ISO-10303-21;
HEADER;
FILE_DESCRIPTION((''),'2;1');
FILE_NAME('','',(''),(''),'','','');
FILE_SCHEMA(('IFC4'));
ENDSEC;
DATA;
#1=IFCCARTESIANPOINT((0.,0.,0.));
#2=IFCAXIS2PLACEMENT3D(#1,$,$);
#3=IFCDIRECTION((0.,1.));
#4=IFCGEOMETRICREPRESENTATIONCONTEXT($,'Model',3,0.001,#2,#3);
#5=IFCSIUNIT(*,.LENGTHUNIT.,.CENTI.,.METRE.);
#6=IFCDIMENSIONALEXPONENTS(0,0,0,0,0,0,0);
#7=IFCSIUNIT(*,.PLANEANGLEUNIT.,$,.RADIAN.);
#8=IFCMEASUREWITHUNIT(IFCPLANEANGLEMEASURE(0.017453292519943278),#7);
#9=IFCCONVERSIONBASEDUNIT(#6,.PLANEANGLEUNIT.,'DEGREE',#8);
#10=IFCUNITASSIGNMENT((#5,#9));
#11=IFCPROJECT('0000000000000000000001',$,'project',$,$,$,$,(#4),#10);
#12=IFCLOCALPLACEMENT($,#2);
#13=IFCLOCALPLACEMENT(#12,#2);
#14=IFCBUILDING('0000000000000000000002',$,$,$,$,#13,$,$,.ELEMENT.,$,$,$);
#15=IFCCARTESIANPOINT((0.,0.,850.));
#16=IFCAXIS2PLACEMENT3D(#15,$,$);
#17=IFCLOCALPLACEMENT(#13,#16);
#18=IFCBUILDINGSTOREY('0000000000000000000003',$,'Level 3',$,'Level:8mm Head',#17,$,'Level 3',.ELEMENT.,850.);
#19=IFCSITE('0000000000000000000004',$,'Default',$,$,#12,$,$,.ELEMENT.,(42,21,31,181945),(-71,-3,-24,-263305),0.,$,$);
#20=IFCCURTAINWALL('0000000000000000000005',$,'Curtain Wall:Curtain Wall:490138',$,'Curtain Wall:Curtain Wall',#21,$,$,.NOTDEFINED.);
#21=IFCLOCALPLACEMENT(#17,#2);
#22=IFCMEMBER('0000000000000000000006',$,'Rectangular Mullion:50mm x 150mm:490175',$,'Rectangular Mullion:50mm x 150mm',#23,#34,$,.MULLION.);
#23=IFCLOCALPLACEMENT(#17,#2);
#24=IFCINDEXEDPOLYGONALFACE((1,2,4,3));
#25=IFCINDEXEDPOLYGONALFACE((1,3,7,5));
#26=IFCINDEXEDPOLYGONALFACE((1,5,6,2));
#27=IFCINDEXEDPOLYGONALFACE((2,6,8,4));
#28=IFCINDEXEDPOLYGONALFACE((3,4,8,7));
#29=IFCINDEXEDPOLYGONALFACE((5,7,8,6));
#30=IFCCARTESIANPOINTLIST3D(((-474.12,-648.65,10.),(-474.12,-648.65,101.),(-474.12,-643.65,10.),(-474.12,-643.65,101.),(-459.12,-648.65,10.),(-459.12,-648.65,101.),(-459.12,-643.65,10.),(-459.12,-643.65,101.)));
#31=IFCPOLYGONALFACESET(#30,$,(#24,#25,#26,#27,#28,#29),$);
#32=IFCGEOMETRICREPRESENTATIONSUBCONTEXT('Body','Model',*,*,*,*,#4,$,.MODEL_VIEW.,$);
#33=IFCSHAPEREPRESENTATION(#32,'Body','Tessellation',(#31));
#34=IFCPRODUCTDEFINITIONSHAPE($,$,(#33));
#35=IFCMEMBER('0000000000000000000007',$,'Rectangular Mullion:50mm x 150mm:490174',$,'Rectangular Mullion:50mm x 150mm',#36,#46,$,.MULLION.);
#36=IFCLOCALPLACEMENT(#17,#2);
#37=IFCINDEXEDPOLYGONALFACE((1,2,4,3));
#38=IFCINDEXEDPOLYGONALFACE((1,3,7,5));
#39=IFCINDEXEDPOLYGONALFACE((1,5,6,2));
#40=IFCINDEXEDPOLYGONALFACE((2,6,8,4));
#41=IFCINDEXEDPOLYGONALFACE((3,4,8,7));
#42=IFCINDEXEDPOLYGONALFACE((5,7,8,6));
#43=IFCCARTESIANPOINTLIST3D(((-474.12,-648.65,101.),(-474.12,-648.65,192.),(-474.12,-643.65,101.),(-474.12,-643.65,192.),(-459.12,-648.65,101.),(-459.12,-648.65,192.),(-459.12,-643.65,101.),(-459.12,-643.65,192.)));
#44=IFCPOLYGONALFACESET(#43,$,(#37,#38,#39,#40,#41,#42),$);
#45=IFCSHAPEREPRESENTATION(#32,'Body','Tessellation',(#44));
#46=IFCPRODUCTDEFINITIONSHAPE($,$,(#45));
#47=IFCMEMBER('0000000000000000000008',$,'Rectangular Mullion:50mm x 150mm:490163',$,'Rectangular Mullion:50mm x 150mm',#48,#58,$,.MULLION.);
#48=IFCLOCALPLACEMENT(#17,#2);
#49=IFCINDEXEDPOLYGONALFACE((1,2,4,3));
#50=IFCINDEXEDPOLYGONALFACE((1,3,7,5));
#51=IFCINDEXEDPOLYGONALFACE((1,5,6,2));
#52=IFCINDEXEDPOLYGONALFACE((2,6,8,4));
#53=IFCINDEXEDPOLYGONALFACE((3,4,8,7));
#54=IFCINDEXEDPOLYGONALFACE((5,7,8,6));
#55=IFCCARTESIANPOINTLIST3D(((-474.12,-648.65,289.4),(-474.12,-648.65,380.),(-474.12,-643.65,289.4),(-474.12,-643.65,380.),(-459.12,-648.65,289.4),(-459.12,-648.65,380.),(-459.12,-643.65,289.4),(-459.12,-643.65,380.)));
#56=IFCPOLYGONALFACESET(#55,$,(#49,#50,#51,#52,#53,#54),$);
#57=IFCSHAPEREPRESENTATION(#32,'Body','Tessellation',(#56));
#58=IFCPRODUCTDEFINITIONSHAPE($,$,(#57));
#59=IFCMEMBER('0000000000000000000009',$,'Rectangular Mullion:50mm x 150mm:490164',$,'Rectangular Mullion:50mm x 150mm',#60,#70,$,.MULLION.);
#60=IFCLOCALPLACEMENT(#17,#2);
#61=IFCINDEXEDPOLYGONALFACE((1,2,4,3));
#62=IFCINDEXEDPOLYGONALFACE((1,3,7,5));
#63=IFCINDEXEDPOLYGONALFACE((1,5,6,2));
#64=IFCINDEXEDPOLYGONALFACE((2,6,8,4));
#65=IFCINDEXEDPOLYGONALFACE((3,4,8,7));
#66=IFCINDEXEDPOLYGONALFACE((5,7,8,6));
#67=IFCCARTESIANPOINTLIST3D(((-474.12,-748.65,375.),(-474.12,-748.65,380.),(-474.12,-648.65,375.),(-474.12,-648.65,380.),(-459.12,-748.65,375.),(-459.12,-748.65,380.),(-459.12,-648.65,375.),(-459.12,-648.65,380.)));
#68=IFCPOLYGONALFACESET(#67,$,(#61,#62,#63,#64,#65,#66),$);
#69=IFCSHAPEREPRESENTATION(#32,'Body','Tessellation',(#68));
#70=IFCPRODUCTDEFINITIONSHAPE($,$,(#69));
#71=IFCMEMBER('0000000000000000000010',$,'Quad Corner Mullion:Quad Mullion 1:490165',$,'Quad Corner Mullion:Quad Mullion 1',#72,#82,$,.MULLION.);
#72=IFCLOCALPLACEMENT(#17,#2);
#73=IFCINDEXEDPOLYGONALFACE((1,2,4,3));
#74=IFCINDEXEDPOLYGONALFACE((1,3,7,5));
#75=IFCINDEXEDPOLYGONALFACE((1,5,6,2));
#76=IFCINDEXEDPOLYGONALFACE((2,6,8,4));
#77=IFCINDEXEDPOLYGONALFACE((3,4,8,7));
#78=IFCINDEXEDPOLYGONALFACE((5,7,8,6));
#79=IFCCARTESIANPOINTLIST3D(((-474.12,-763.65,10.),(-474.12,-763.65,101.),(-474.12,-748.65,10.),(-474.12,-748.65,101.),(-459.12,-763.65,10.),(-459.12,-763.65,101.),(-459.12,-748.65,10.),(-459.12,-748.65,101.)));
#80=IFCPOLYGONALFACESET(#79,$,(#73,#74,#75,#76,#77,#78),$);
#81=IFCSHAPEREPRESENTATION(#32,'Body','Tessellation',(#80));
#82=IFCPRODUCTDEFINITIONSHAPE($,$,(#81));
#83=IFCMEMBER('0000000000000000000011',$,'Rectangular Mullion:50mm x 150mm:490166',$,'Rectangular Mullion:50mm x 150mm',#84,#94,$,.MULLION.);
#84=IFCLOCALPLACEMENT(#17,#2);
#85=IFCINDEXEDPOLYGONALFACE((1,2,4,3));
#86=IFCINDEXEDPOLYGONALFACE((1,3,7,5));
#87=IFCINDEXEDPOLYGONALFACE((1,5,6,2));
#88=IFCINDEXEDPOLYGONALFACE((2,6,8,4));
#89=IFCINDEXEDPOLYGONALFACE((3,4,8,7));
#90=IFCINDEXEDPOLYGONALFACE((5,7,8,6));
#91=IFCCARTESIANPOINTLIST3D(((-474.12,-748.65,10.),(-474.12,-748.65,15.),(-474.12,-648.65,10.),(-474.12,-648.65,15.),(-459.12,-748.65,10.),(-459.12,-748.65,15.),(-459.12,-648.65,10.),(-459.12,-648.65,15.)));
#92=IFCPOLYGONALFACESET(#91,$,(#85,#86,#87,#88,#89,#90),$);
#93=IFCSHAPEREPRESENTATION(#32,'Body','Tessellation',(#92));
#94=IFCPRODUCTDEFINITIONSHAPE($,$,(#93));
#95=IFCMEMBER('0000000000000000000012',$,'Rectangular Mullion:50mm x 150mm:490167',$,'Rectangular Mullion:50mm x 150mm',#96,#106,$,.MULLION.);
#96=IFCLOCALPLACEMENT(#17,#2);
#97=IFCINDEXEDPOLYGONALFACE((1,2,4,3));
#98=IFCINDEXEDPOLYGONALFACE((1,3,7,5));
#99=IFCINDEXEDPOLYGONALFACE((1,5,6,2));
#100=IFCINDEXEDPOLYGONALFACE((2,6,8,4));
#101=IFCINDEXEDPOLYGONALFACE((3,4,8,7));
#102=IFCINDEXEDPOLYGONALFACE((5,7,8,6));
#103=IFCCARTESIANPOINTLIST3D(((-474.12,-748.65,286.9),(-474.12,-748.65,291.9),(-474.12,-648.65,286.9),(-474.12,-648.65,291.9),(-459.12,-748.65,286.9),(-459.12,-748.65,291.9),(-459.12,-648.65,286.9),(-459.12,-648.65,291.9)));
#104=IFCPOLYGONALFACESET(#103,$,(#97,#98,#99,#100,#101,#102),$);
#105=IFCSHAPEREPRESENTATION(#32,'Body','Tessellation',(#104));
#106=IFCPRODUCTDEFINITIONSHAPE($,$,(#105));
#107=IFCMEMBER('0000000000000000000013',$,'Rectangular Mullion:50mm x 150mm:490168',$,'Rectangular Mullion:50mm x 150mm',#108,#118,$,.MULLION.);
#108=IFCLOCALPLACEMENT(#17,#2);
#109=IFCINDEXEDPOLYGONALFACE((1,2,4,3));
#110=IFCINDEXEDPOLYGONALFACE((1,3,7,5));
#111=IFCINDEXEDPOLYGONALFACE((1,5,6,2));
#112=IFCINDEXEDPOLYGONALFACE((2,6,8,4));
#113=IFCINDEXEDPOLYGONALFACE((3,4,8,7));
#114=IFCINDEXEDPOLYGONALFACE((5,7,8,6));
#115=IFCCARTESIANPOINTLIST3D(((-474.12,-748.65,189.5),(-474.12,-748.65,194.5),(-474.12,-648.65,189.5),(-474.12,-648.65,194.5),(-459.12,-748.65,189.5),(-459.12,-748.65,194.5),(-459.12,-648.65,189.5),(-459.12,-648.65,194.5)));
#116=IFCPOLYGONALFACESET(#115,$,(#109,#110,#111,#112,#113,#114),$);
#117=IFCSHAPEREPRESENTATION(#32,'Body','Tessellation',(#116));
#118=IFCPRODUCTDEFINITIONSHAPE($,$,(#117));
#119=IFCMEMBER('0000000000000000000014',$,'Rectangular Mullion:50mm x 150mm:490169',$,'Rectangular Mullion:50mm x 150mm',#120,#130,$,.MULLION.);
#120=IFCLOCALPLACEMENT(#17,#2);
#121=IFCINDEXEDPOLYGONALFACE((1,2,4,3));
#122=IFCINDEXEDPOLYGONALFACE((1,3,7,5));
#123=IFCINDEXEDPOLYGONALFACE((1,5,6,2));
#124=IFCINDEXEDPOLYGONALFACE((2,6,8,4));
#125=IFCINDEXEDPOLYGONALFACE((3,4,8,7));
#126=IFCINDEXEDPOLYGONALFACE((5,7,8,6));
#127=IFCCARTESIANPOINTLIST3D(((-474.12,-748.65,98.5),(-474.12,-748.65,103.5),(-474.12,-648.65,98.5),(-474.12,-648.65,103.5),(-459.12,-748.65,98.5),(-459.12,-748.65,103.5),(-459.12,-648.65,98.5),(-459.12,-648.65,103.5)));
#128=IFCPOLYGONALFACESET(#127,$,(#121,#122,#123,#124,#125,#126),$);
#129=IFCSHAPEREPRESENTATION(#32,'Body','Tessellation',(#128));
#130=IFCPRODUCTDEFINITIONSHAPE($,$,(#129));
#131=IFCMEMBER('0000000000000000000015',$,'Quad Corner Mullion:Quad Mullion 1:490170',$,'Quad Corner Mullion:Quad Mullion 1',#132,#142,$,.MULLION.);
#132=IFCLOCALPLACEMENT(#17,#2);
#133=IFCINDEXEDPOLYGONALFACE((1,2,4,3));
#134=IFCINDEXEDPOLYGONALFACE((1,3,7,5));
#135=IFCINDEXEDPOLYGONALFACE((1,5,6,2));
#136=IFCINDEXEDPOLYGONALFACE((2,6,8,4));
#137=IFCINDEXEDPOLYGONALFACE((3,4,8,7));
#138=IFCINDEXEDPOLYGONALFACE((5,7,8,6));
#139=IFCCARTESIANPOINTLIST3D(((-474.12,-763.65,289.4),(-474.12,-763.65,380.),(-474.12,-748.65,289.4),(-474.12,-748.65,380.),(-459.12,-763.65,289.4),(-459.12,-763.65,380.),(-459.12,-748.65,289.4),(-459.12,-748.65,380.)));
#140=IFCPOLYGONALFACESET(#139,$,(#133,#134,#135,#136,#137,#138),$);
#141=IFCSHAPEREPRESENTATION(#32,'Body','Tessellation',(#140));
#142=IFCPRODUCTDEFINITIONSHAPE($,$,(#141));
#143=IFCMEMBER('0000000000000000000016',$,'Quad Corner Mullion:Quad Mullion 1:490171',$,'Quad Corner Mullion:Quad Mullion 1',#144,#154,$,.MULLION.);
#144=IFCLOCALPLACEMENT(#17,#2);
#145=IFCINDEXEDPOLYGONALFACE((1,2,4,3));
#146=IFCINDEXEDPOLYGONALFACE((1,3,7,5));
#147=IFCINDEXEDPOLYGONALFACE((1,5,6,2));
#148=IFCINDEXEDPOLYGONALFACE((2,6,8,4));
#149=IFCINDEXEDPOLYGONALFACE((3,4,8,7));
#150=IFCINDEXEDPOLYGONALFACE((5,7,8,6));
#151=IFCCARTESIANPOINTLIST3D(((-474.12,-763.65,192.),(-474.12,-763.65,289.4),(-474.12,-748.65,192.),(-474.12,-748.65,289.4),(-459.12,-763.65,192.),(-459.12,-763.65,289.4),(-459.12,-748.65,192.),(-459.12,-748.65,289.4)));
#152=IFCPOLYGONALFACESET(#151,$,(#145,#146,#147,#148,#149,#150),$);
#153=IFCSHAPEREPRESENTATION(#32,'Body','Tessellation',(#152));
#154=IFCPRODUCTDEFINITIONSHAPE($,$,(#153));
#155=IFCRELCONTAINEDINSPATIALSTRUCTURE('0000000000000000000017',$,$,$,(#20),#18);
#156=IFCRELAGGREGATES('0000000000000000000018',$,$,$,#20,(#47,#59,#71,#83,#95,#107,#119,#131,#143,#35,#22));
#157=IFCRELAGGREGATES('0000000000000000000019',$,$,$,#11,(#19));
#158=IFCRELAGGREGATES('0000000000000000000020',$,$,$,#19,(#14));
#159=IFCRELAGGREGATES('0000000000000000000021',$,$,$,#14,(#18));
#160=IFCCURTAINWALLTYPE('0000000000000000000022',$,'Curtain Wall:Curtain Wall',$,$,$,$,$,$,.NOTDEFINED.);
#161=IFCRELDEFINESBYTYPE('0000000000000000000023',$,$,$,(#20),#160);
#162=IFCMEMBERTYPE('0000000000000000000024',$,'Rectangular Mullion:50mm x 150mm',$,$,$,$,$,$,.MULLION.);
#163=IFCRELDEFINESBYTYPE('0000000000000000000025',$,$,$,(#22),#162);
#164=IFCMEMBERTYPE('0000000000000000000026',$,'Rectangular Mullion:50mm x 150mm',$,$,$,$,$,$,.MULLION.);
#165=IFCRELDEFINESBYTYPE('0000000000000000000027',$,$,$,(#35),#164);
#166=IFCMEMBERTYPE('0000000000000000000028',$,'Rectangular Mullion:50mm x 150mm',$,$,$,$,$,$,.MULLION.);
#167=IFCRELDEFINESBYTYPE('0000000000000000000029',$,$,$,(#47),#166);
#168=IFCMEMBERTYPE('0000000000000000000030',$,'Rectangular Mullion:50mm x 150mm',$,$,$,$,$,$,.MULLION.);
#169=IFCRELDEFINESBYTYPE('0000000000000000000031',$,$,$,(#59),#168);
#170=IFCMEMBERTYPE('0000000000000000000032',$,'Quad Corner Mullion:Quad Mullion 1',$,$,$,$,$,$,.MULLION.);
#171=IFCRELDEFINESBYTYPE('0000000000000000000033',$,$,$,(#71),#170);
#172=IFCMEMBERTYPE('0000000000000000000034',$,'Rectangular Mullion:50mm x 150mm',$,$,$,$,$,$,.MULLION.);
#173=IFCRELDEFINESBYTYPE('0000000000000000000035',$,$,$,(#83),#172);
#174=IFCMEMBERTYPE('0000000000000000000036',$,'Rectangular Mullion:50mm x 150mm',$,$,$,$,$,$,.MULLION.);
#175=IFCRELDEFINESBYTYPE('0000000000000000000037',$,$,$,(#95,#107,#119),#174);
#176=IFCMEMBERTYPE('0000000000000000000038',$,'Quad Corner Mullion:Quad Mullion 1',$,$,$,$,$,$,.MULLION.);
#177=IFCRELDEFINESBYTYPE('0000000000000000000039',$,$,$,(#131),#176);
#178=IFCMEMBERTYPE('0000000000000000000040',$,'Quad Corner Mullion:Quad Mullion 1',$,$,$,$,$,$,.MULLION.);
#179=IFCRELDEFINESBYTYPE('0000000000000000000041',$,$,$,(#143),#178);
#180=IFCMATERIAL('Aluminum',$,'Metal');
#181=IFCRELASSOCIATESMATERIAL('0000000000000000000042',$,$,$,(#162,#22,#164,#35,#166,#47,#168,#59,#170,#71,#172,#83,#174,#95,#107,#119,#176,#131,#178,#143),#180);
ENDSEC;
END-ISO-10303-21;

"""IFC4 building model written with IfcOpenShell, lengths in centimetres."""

from ifc_helpers import new_model, entity, si_unit, converted_unit, direction, frame, origin, place, context, subcontext, project, spatial, indexed_curve, outline, extrude, source, transform, mapped, material, type_object, type_shapes, element, aggregate, save


model = new_model("IFC4")

# Units and contexts
model_context = context("Model", 3, precision=0.001, world=origin(), true_north=direction((0.0, 1.0)))
body_context = subcontext(model_context, "Body", "Model", "MODEL_VIEW")
ifc_project = project(units=[si_unit("LENGTHUNIT", "METRE", prefix="CENTI"), converted_unit("PLANEANGLEUNIT", "DEGREE", entity("IfcPlaneAngleMeasure", 0.017453292519943278), si_unit("PLANEANGLEUNIT", "RADIAN"), dimensions=[0, 0, 0, 0, 0, 0, 0])], contexts=[model_context])

# Site, building, storey
site_placement = place(None, origin())
site = spatial("IfcSite", under=ifc_project, at=site_placement, Name="Default", CompositionType="ELEMENT", RefLatitude=(42, 21, 31, 181945), RefLongitude=(-71, -3, -24, -263305), RefElevation=0.0)
building_placement = place(site_placement, origin())
building = spatial("IfcBuilding", under=site, at=building_placement, CompositionType="ELEMENT")
storey_placement = place(building_placement, frame((0.0, 0.0, 850.0)))
storey = spatial("IfcBuildingStorey", under=building, at=storey_placement, Name="Level 3", ObjectType="Level:8mm Head", LongName="Level 3", CompositionType="ELEMENT", Elevation=850.0)

# Curtain wall, members
curtain_wall_type = type_object("IfcCurtainWallType", Name="Curtain Wall:Curtain Wall", PredefinedType="NOTDEFINED")
curtain_wall_1_placement = place(storey_placement, frame((0.0, 0.0, -850.0)))
curtain_wall_1 = element("IfcCurtainWall", 1, at=curtain_wall_1_placement, inside=storey, type_object=curtain_wall_type, Name="Curtain Wall:Curtain Wall:490138", ObjectType="Curtain Wall:Curtain Wall", PredefinedType="NOTDEFINED")
ifc_material_1 = material(Name="Aluminum", Category="Metal")
member_type_1 = type_object("IfcMemberType", Name="Rectangular Mullion:50mm x 150mm", PredefinedType="MULLION", material=ifc_material_1)
shared_shape_1 = source(origin(), body_context, "Body", "SweptSolid", [
    extrude(outline(indexed_curve([(-2.5, -7.5), (2.5, -7.5), (2.5, 7.5), (-2.5, 7.5), (-2.5, -7.5)], self_intersect=False)), frame((-2.5, 0.0, -91.0), z_axis=(0.0, 0.0, 1.0), x_axis=(-1.0, 0.0, 0.0)), (0.0, 0.0, 1.0), 91.0),
])
type_shapes(member_type_1, [shared_shape_1])
member_1_placement = place(curtain_wall_1_placement, frame((-466.62, -643.65, 951.0), z_axis=(0.0, 0.0, 1.0), x_axis=(0.0, 1.0, 0.0)))
member_1 = element("IfcMember", 2, at=member_1_placement, type_object=member_type_1, material=ifc_material_1, Name="Rectangular Mullion:50mm x 150mm:490175", ObjectType="Rectangular Mullion:50mm x 150mm", PredefinedType="MULLION", context=body_context, shape_type="MappedRepresentation", body=[
    mapped(shared_shape_1, transform((0.0, 0.0, 0.0), scale=1.0)),
])
member_type_2 = type_object("IfcMemberType", Name="Rectangular Mullion:50mm x 150mm", PredefinedType="MULLION", material=ifc_material_1)
shared_shape_2 = source(origin(), body_context, "Body", "SweptSolid", [
    extrude(outline(indexed_curve([(-2.5, -7.5), (2.5, -7.5), (2.5, 7.5), (-2.5, 7.5), (-2.5, -7.5)], self_intersect=False)), frame((-2.5, 0.0, -91.0), z_axis=(0.0, 0.0, 1.0), x_axis=(-1.0, 0.0, 0.0)), (0.0, 0.0, 1.0), 91.0),
])
type_shapes(member_type_2, [shared_shape_2])
member_2_placement = place(curtain_wall_1_placement, frame((-466.62, -643.65, 1042.0), z_axis=(0.0, 0.0, 1.0), x_axis=(0.0, 1.0, 0.0)))
member_2 = element("IfcMember", 3, at=member_2_placement, type_object=member_type_2, material=ifc_material_1, Name="Rectangular Mullion:50mm x 150mm:490174", ObjectType="Rectangular Mullion:50mm x 150mm", PredefinedType="MULLION", context=body_context, shape_type="MappedRepresentation", body=[
    mapped(shared_shape_2, transform((0.0, 0.0, 0.0), scale=1.0)),
])
member_type_3 = type_object("IfcMemberType", Name="Rectangular Mullion:50mm x 150mm", PredefinedType="MULLION", material=ifc_material_1)
shared_shape_3 = source(origin(), body_context, "Body", "SweptSolid", [
    extrude(outline(indexed_curve([(-2.5, -7.5), (2.5, -7.5), (2.5, 7.5), (-2.5, 7.5), (-2.5, -7.5)], self_intersect=False)), frame((-2.5, 0.0, -90.6), z_axis=(0.0, 0.0, 1.0), x_axis=(-1.0, 0.0, 0.0)), (0.0, 0.0, 1.0), 90.6),
])
type_shapes(member_type_3, [shared_shape_3])
member_3_placement = place(curtain_wall_1_placement, frame((-466.62, -643.65, 1230.0), z_axis=(0.0, 0.0, 1.0), x_axis=(0.0, 1.0, 0.0)))
member_3 = element("IfcMember", 4, at=member_3_placement, type_object=member_type_3, material=ifc_material_1, Name="Rectangular Mullion:50mm x 150mm:490163", ObjectType="Rectangular Mullion:50mm x 150mm", PredefinedType="MULLION", context=body_context, shape_type="MappedRepresentation", body=[
    mapped(shared_shape_3, transform((0.0, 0.0, 0.0), scale=1.0)),
])
member_type_4 = type_object("IfcMemberType", Name="Rectangular Mullion:50mm x 150mm", PredefinedType="MULLION", material=ifc_material_1)
shared_shape_4 = source(origin(), body_context, "Body", "SweptSolid", [
    extrude(outline(indexed_curve([(-2.5, -7.5), (2.5, -7.5), (2.5, 7.5), (-2.5, 7.5), (-2.5, -7.5)], self_intersect=False)), frame((-2.5, 0.0, -100.0), z_axis=(0.0, 0.0, 1.0), x_axis=(-1.0, 0.0, 0.0)), (0.0, 0.0, 1.0), 100.0),
])
type_shapes(member_type_4, [shared_shape_4])
member_4_placement = place(curtain_wall_1_placement, frame((-466.62, -748.65, 1230.0), z_axis=(0.0, -1.0, 0.0), x_axis=(0.0, 0.0, 1.0)))
member_4 = element("IfcMember", 5, at=member_4_placement, type_object=member_type_4, material=ifc_material_1, Name="Rectangular Mullion:50mm x 150mm:490164", ObjectType="Rectangular Mullion:50mm x 150mm", PredefinedType="MULLION", context=body_context, shape_type="MappedRepresentation", body=[
    mapped(shared_shape_4, transform((0.0, 0.0, 0.0), scale=1.0)),
])
member_type_5 = type_object("IfcMemberType", Name="Quad Corner Mullion:Quad Mullion 1", PredefinedType="MULLION", material=ifc_material_1)
shared_shape_5 = source(origin(), body_context, "Body", "SweptSolid", [
    extrude(outline(indexed_curve([(-7.5, -7.5), (7.5, -7.5), (7.5, 7.5), (-7.5, 7.5), (-7.5, -7.5)], self_intersect=False)), frame((0.0, 0.0, -91.0), z_axis=(0.0, 0.0, 1.0), x_axis=(0.0, 1.0, 0.0)), (0.0, 0.0, 1.0), 91.0),
])
type_shapes(member_type_5, [shared_shape_5])
member_5_placement = place(curtain_wall_1_placement, frame((-466.62, -756.15, 860.0), z_axis=(0.0, 0.0, -1.0), x_axis=(0.0, -1.0, 0.0)))
member_5 = element("IfcMember", 6, at=member_5_placement, type_object=member_type_5, material=ifc_material_1, Name="Quad Corner Mullion:Quad Mullion 1:490165", ObjectType="Quad Corner Mullion:Quad Mullion 1", PredefinedType="MULLION", context=body_context, shape_type="MappedRepresentation", body=[
    mapped(shared_shape_5, transform((0.0, 0.0, 0.0), scale=1.0)),
])
member_type_6 = type_object("IfcMemberType", Name="Rectangular Mullion:50mm x 150mm", PredefinedType="MULLION", material=ifc_material_1)
shared_shape_6 = source(origin(), body_context, "Body", "SweptSolid", [
    extrude(outline(indexed_curve([(-2.5, -7.5), (2.5, -7.5), (2.5, 7.5), (-2.5, 7.5), (-2.5, -7.5)], self_intersect=False)), frame((-2.5, 0.0, -100.0), z_axis=(0.0, 0.0, 1.0), x_axis=(-1.0, 0.0, 0.0)), (0.0, 0.0, 1.0), 100.0),
])
type_shapes(member_type_6, [shared_shape_6])
member_6_placement = place(curtain_wall_1_placement, frame((-466.62, -648.65, 860.0), z_axis=(0.0, 1.0, 0.0), x_axis=(0.0, 0.0, -1.0)))
member_6 = element("IfcMember", 7, at=member_6_placement, type_object=member_type_6, material=ifc_material_1, Name="Rectangular Mullion:50mm x 150mm:490166", ObjectType="Rectangular Mullion:50mm x 150mm", PredefinedType="MULLION", context=body_context, shape_type="MappedRepresentation", body=[
    mapped(shared_shape_6, transform((0.0, 0.0, 0.0), scale=1.0)),
])
member_type_7 = type_object("IfcMemberType", Name="Rectangular Mullion:50mm x 150mm", PredefinedType="MULLION", material=ifc_material_1)
shared_shape_7 = source(origin(), body_context, "Body", "SweptSolid", [
    extrude(outline(indexed_curve([(-2.5, -7.5), (2.5, -7.5), (2.5, 7.5), (-2.5, 7.5), (-2.5, -7.5)], self_intersect=False)), frame((0.0, 0.0, -100.0), z_axis=(0.0, 0.0, 1.0), x_axis=(-1.0, 0.0, 0.0)), (0.0, 0.0, 1.0), 100.0),
])
type_shapes(member_type_7, [shared_shape_7])
member_7_placement = place(curtain_wall_1_placement, frame((-466.62, -748.65, 1139.4), z_axis=(0.0, -1.0, 0.0), x_axis=(0.0, 0.0, 1.0)))
member_7 = element("IfcMember", 8, at=member_7_placement, type_object=member_type_7, material=ifc_material_1, Name="Rectangular Mullion:50mm x 150mm:490167", ObjectType="Rectangular Mullion:50mm x 150mm", PredefinedType="MULLION", context=body_context, shape_type="MappedRepresentation", body=[
    mapped(shared_shape_7, transform((0.0, 0.0, 0.0), scale=1.0)),
])
member_8_placement = place(curtain_wall_1_placement, frame((-466.62, -748.65, 1042.0), z_axis=(0.0, -1.0, 0.0), x_axis=(0.0, 0.0, 1.0)))
member_8 = element("IfcMember", 9, at=member_8_placement, type_object=member_type_7, material=ifc_material_1, Name="Rectangular Mullion:50mm x 150mm:490168", ObjectType="Rectangular Mullion:50mm x 150mm", PredefinedType="MULLION", context=body_context, shape_type="MappedRepresentation", body=[
    mapped(shared_shape_7, transform((0.0, 0.0, 0.0), scale=1.0)),
])
member_9_placement = place(curtain_wall_1_placement, frame((-466.62, -748.65, 951.0), z_axis=(0.0, -1.0, 0.0), x_axis=(0.0, 0.0, 1.0)))
member_9 = element("IfcMember", 10, at=member_9_placement, type_object=member_type_7, material=ifc_material_1, Name="Rectangular Mullion:50mm x 150mm:490169", ObjectType="Rectangular Mullion:50mm x 150mm", PredefinedType="MULLION", context=body_context, shape_type="MappedRepresentation", body=[
    mapped(shared_shape_7, transform((0.0, 0.0, 0.0), scale=1.0)),
])
member_type_8 = type_object("IfcMemberType", Name="Quad Corner Mullion:Quad Mullion 1", PredefinedType="MULLION", material=ifc_material_1)
shared_shape_8 = source(origin(), body_context, "Body", "SweptSolid", [
    extrude(outline(indexed_curve([(-7.5, -7.5), (7.5, -7.5), (7.5, 7.5), (-7.5, 7.5), (-7.5, -7.5)], self_intersect=False)), frame((0.0, 0.0, -90.6), z_axis=(0.0, 0.0, 1.0), x_axis=(0.0, 1.0, 0.0)), (0.0, 0.0, 1.0), 90.6),
])
type_shapes(member_type_8, [shared_shape_8])
member_10_placement = place(curtain_wall_1_placement, frame((-466.62, -756.15, 1139.4), z_axis=(0.0, 0.0, -1.0), x_axis=(0.0, -1.0, 0.0)))
member_10 = element("IfcMember", 11, at=member_10_placement, type_object=member_type_8, material=ifc_material_1, Name="Quad Corner Mullion:Quad Mullion 1:490170", ObjectType="Quad Corner Mullion:Quad Mullion 1", PredefinedType="MULLION", context=body_context, shape_type="MappedRepresentation", body=[
    mapped(shared_shape_8, transform((0.0, 0.0, 0.0), scale=1.0)),
])
member_type_9 = type_object("IfcMemberType", Name="Quad Corner Mullion:Quad Mullion 1", PredefinedType="MULLION", material=ifc_material_1)
shared_shape_9 = source(origin(), body_context, "Body", "SweptSolid", [
    extrude(outline(indexed_curve([(-7.5, -7.5), (7.5, -7.5), (7.5, 7.5), (-7.5, 7.5), (-7.5, -7.5)], self_intersect=False)), frame((0.0, 0.0, -97.4), z_axis=(0.0, 0.0, 1.0), x_axis=(0.0, 1.0, 0.0)), (0.0, 0.0, 1.0), 97.4),
])
type_shapes(member_type_9, [shared_shape_9])
member_11_placement = place(curtain_wall_1_placement, frame((-466.62, -756.15, 1042.0), z_axis=(0.0, 0.0, -1.0), x_axis=(0.0, -1.0, 0.0)))
member_11 = element("IfcMember", 12, at=member_11_placement, type_object=member_type_9, material=ifc_material_1, Name="Quad Corner Mullion:Quad Mullion 1:490171", ObjectType="Quad Corner Mullion:Quad Mullion 1", PredefinedType="MULLION", context=body_context, shape_type="MappedRepresentation", body=[
    mapped(shared_shape_9, transform((0.0, 0.0, 0.0), scale=1.0)),
])

aggregate(curtain_wall_1, [member_3, member_4, member_5, member_6, member_7, member_8, member_9, member_10, member_11, member_2, member_1])

save(model, "model.ifc")
